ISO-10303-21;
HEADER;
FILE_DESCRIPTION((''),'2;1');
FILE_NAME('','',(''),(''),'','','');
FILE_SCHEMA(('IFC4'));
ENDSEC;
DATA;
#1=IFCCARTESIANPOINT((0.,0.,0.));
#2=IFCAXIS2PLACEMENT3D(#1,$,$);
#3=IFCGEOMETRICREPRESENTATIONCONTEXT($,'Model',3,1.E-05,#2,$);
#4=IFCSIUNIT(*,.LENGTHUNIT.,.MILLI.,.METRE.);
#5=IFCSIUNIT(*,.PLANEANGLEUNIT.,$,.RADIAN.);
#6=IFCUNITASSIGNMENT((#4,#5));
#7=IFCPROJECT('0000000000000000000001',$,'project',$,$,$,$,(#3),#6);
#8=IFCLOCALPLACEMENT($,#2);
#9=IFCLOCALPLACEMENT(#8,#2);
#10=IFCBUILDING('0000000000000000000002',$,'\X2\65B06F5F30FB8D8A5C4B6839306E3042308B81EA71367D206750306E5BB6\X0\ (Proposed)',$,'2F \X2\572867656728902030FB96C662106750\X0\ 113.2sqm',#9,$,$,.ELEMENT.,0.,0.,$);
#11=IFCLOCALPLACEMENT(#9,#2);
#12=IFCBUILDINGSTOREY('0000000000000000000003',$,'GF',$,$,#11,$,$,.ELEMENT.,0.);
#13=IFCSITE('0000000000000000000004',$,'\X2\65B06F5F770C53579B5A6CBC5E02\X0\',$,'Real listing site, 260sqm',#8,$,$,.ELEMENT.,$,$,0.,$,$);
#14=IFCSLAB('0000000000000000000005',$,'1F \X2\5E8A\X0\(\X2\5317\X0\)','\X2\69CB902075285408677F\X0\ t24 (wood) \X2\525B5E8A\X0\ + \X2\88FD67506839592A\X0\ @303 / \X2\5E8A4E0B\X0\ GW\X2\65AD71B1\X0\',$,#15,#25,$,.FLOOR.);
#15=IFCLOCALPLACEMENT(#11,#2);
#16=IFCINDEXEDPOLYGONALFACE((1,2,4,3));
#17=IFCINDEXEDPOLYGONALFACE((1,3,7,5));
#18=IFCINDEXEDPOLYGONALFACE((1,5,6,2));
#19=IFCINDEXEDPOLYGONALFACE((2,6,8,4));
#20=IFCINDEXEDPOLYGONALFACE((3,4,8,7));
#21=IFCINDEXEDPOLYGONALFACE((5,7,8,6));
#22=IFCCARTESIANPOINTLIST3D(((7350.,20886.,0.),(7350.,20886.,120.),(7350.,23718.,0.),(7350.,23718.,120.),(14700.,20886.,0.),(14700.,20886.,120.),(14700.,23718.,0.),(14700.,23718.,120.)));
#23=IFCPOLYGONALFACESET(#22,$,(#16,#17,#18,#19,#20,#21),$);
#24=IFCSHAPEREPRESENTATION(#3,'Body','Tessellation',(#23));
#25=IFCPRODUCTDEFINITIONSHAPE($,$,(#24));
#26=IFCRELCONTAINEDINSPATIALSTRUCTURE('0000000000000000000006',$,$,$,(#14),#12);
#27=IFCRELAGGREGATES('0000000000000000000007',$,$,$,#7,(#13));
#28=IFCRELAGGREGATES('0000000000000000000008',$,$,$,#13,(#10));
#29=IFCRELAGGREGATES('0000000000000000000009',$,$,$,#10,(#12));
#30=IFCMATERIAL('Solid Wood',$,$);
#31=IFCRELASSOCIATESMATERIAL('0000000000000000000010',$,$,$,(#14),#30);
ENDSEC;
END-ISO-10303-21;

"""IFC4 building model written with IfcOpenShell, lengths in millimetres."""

from ifc_helpers import new_model, si_unit, frame, frame_2d, origin, place, context, project, spatial, rectangle, extrude, material, element, save


model = new_model("IFC4")

# Units and contexts
model_context = context("Model", 3, precision=1e-05, world=origin())
ifc_project = project(units=[si_unit("LENGTHUNIT", "METRE", prefix="MILLI"), si_unit("PLANEANGLEUNIT", "RADIAN")], contexts=[model_context])

# Site, building, storey
site_placement = place(None, origin())
site = spatial("IfcSite", under=ifc_project, at=site_placement, Name="新潟県南魚沼市", ObjectType="Real listing site, 260sqm", CompositionType="ELEMENT", RefElevation=0.0)
building_placement = place(site_placement, origin())
building = spatial("IfcBuilding", under=site, at=building_placement, Name="新潟・越屋根のある自然素材の家 (Proposed)", ObjectType="2F 在来木造・集成材 113.2sqm", CompositionType="ELEMENT", ElevationOfRefHeight=0.0, ElevationOfTerrain=0.0)
storey_placement = place(building_placement, origin())
storey = spatial("IfcBuildingStorey", under=building, at=storey_placement, Name="GF", CompositionType="ELEMENT", Elevation=0.0)

# Shared definitions
ifc_material_1 = material(Name="Solid Wood")

# Slab
slab_1_placement = place(storey_placement, frame((3675.0, 10443.0, 0.0)))
element("IfcSlab", 1, at=slab_1_placement, inside=storey, material=ifc_material_1, Name="1F 床(北)", Description="構造用合板 t24 (wood) 剛床 + 製材根太 @303 / 床下 GW断熱", PredefinedType="FLOOR", context=model_context, shape_type="SweptSolid", body=[
    extrude(rectangle(XDim=7350.0, YDim=2832.0, at=frame_2d((3675.0, 1416.0))), frame((3675.0, 10443.0, 0.0)), (0.0, 0.0, 1.0), 120.0),
])

save(model, "model.ifc")
